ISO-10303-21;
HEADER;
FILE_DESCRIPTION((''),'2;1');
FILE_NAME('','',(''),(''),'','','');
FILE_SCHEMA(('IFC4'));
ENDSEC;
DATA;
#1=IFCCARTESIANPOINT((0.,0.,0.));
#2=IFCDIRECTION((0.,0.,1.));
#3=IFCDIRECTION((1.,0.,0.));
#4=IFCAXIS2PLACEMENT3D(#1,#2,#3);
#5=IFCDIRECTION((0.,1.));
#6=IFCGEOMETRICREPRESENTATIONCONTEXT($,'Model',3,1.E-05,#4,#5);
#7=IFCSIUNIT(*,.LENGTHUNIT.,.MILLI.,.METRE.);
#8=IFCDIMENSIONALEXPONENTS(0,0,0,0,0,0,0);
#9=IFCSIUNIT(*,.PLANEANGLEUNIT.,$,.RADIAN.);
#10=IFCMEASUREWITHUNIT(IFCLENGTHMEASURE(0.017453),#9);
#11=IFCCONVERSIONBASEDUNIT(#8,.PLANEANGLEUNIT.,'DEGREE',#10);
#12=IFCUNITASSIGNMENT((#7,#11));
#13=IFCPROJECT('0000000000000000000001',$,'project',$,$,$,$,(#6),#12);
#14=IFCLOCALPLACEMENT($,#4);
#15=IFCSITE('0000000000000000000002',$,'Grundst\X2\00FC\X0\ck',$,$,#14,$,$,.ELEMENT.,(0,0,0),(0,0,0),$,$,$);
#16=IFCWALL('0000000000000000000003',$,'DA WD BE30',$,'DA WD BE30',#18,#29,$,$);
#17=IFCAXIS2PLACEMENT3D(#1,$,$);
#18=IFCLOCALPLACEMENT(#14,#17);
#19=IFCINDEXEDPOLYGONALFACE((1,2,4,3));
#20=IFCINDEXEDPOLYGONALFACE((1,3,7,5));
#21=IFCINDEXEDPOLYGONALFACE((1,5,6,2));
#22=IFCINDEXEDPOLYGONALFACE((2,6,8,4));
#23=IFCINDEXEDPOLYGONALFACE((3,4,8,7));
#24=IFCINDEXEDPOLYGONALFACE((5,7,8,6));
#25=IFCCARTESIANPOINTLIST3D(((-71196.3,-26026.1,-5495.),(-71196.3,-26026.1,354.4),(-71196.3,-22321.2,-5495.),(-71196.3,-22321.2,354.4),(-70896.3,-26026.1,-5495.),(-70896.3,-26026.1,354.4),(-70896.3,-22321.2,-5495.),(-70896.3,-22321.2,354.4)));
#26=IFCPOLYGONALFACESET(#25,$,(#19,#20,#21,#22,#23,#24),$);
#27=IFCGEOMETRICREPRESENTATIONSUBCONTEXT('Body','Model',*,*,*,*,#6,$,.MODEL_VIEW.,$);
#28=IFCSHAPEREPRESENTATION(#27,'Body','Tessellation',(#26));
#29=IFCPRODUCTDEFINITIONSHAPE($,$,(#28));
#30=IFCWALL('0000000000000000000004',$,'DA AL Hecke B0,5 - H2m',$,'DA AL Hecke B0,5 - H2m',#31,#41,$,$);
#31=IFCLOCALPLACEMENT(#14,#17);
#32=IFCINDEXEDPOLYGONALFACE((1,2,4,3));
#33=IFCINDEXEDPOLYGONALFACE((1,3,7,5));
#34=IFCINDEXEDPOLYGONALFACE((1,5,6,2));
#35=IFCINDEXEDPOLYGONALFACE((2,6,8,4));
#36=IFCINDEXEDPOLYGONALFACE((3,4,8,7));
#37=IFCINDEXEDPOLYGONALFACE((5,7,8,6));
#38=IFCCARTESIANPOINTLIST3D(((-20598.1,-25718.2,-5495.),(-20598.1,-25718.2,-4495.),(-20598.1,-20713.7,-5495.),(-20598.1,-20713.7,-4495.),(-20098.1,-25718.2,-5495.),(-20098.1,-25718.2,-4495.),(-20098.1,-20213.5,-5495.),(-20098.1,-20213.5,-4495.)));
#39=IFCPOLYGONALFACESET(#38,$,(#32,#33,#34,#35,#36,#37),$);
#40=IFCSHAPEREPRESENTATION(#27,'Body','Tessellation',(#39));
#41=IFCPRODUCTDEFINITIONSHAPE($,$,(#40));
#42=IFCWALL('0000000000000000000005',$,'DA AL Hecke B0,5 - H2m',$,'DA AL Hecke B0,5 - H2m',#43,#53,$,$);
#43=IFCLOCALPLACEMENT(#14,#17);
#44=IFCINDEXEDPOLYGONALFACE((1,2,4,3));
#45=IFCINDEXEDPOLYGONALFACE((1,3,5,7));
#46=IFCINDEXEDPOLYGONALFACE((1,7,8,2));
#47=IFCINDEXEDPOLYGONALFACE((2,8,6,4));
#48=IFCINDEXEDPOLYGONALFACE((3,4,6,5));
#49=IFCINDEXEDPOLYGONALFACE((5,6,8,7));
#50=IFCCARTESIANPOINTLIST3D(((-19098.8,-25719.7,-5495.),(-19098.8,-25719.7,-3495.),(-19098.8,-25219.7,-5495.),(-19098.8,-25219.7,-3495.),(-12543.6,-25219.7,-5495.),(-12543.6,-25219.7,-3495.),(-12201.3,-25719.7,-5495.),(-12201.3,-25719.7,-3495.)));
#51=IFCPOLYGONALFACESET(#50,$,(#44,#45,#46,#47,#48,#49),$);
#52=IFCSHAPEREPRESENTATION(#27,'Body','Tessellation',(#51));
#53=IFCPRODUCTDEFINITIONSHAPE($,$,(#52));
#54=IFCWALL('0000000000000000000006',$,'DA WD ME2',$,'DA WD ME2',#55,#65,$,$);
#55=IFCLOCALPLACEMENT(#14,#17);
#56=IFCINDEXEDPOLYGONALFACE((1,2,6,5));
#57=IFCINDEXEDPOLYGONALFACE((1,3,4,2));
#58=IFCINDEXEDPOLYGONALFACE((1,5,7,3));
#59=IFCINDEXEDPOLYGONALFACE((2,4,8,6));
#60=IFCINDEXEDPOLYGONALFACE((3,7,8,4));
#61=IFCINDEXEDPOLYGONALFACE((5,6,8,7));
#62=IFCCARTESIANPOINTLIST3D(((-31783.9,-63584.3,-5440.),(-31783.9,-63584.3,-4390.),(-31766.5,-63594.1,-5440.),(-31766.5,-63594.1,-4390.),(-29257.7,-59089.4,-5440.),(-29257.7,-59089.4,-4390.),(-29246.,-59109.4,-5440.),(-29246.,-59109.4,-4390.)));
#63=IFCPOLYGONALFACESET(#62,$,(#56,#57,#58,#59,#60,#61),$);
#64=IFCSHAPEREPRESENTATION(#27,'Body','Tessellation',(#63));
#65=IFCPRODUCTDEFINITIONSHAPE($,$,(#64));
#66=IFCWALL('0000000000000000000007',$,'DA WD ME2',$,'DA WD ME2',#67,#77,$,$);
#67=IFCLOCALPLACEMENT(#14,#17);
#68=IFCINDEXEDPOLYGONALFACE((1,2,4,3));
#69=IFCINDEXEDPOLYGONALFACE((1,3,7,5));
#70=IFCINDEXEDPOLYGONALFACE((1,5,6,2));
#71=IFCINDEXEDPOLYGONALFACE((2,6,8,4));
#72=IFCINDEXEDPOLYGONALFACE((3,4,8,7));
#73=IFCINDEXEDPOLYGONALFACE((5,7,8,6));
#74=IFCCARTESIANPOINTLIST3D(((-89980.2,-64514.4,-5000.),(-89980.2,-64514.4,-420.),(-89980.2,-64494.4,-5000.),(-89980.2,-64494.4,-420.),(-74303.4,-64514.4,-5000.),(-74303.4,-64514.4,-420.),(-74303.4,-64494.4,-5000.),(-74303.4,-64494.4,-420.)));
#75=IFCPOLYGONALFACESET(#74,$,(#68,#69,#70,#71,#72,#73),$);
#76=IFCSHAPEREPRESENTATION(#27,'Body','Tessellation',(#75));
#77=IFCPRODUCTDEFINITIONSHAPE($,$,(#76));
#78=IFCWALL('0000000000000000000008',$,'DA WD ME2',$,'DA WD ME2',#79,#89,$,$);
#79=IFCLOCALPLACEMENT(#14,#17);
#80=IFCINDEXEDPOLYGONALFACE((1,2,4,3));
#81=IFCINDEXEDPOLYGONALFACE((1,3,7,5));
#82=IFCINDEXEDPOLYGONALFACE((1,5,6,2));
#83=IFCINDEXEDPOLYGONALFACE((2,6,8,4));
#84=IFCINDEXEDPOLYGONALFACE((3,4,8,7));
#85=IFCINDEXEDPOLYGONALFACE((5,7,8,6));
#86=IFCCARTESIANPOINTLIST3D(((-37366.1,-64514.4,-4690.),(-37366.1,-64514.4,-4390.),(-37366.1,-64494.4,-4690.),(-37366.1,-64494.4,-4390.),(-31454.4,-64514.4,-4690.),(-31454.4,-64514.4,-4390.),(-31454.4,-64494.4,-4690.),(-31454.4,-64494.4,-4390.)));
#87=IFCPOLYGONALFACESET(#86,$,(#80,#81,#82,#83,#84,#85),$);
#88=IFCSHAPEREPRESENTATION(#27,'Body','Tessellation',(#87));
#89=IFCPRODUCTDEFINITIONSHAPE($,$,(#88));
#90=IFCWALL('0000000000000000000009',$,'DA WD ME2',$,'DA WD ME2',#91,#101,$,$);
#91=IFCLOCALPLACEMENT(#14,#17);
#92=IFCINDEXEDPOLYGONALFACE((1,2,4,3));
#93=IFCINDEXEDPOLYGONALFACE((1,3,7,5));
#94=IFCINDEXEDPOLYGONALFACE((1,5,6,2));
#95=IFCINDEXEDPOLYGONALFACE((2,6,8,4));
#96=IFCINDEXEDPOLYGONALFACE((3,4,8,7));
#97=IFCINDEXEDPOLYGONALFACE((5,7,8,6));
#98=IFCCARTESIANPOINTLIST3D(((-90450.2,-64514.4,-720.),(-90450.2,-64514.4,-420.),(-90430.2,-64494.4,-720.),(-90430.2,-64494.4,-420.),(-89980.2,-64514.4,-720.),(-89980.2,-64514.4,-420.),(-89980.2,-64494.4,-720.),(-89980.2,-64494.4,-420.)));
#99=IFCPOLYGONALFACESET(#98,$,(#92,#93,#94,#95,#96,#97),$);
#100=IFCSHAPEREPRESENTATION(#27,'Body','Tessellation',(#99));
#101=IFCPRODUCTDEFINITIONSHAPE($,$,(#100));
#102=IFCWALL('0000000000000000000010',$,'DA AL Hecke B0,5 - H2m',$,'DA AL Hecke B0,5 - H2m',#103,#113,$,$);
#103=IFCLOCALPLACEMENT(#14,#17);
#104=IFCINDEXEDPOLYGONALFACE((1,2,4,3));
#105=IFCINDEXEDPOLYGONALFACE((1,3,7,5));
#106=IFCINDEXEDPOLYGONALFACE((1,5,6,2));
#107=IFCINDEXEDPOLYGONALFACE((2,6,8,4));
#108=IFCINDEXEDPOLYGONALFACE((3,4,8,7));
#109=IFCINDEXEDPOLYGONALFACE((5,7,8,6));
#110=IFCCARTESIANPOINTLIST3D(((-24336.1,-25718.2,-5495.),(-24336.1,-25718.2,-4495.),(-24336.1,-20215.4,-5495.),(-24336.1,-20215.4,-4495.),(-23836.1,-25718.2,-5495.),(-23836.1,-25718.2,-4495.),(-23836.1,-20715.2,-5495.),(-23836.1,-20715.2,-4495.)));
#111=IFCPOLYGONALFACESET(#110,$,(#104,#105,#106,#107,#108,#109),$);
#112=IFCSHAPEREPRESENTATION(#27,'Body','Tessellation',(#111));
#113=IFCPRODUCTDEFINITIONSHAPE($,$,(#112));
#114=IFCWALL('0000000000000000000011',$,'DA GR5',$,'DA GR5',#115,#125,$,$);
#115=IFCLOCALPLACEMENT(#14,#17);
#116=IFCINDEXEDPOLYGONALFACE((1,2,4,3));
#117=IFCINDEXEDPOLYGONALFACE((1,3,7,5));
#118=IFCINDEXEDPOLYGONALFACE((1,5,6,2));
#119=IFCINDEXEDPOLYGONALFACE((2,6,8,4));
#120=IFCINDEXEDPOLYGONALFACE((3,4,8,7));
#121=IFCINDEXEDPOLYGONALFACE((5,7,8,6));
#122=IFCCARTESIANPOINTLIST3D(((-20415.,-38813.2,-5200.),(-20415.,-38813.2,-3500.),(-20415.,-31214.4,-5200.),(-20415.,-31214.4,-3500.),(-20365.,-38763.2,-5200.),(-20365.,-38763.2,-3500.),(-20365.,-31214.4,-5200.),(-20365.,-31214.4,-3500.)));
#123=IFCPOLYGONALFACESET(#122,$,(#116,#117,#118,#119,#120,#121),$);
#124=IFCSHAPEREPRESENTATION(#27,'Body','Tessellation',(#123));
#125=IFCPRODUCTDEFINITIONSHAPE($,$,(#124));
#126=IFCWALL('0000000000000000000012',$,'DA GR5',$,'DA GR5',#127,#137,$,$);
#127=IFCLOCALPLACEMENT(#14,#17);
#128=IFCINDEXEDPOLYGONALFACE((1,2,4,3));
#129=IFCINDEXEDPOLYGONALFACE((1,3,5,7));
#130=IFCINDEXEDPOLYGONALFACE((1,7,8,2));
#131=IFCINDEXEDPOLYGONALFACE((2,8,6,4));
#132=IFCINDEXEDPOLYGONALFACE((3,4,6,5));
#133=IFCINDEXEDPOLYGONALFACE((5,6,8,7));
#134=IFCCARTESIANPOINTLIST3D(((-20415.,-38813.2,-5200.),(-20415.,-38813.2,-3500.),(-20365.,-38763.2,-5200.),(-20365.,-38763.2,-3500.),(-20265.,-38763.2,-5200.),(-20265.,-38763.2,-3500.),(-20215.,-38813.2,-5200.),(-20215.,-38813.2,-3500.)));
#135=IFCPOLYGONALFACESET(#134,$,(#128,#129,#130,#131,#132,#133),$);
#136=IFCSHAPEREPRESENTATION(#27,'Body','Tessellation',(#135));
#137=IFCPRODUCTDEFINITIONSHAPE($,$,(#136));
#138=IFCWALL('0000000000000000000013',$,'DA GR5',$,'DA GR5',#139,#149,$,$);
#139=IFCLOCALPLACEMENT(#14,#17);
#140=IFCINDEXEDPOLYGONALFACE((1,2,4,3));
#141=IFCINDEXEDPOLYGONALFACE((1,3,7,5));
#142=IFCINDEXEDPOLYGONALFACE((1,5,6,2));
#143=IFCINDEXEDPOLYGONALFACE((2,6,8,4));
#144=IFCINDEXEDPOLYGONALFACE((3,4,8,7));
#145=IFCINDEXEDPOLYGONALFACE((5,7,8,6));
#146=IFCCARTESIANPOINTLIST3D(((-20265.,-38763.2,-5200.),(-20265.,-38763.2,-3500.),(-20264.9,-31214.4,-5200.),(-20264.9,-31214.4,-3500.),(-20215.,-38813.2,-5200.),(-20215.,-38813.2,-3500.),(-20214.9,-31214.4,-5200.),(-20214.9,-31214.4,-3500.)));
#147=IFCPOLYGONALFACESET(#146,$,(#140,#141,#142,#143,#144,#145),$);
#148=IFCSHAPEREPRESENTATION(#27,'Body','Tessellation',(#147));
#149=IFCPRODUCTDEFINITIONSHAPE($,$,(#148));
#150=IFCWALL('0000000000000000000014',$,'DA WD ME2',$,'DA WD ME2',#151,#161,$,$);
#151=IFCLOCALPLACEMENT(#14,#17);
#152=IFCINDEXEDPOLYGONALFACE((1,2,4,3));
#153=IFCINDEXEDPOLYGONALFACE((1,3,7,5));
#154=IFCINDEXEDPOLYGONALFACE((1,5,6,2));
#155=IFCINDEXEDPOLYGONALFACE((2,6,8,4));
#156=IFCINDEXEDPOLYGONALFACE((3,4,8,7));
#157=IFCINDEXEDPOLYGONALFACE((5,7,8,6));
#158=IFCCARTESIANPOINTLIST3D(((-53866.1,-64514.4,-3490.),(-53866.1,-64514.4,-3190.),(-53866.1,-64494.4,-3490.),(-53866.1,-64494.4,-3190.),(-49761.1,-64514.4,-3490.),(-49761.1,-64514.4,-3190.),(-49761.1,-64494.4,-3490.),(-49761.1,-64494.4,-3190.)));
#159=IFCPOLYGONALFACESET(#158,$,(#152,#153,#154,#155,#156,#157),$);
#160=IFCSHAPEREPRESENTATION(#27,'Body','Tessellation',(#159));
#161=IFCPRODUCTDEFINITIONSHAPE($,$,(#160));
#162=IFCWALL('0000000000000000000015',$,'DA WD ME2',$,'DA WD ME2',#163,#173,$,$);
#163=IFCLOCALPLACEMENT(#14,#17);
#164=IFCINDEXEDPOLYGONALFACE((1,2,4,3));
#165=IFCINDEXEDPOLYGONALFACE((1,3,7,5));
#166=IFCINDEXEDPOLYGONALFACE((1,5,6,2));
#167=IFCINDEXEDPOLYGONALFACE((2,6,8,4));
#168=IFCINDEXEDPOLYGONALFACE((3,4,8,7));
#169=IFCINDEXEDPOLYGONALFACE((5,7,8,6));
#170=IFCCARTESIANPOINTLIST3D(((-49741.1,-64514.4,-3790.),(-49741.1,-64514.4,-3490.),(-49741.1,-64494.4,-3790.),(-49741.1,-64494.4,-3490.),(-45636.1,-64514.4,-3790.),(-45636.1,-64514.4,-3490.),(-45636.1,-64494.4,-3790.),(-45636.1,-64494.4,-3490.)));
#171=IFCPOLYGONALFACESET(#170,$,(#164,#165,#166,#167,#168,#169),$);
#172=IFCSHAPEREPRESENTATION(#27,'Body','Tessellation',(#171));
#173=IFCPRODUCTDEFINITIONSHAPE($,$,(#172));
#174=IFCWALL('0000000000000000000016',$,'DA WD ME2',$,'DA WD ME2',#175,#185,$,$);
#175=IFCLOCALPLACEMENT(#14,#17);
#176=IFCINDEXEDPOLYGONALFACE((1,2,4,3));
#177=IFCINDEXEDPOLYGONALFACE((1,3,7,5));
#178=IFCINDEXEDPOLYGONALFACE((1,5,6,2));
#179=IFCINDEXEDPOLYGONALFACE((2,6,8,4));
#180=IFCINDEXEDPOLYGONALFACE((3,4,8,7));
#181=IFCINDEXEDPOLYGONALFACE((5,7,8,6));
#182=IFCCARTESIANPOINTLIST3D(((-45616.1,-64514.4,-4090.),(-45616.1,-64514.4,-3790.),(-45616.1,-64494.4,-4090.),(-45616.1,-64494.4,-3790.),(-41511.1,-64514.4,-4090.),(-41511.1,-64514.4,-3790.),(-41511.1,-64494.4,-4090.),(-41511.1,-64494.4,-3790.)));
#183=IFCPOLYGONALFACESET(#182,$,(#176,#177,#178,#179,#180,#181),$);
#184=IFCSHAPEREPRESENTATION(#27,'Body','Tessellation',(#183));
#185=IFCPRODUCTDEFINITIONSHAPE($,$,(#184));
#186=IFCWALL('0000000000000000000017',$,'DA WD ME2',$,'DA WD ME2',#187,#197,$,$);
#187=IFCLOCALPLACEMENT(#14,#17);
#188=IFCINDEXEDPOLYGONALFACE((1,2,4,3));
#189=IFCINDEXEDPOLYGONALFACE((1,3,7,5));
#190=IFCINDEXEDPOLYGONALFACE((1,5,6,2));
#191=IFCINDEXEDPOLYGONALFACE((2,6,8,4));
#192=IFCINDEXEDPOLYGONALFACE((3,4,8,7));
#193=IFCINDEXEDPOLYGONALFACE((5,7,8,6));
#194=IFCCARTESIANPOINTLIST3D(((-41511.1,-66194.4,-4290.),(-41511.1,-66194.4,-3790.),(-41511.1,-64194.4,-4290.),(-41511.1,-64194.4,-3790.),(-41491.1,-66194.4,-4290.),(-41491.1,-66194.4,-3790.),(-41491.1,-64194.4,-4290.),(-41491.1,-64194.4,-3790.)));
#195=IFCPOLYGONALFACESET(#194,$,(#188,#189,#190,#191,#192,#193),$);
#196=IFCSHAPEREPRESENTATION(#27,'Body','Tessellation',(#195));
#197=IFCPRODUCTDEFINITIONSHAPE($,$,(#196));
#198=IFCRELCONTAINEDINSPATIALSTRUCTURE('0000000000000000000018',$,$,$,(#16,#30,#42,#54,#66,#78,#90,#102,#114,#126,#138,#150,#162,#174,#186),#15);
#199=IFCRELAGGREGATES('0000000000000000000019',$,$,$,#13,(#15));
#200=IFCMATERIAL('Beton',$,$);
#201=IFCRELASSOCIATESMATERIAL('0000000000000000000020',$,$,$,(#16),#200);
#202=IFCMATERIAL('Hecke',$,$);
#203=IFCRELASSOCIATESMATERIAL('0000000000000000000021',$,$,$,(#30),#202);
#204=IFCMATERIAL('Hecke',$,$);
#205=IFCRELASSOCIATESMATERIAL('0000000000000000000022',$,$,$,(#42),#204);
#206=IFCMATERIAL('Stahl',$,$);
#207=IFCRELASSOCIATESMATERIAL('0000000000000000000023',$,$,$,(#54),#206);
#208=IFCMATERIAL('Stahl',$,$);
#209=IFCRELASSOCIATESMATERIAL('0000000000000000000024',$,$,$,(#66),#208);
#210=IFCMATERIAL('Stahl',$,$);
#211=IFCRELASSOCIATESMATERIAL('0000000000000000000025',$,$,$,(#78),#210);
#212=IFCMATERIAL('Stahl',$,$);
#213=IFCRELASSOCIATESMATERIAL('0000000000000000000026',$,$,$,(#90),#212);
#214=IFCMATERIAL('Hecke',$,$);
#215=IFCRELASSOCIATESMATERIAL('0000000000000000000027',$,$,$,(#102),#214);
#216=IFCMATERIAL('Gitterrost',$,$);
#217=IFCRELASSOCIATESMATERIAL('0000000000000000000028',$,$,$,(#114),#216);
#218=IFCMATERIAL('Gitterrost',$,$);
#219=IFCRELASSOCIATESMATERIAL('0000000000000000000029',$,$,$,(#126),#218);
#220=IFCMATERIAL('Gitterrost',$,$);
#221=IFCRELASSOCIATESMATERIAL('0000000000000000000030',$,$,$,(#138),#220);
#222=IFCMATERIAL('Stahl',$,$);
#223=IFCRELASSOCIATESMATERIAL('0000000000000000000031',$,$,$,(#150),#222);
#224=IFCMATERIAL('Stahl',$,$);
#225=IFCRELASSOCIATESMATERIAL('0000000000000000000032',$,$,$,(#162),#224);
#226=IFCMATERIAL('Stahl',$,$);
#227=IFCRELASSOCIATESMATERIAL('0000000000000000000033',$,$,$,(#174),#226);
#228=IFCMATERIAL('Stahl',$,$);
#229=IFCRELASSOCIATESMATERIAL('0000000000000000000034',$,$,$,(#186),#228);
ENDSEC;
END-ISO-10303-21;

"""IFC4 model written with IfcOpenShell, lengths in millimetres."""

from ifc_helpers import new_model, entity, si_unit, converted_unit, direction, frame, origin_with_axes, place, context, subcontext, project, spatial, line, indexed_curve, outline, extrude, material, element, save


model = new_model("IFC4")

# Units and contexts
model_context = context("Model", 3, precision=1e-05, world=origin_with_axes(), true_north=direction((0.0, 1.0)))
body_context = subcontext(model_context, "Body", "Model", "MODEL_VIEW")
ifc_project = project(units=[si_unit("LENGTHUNIT", "METRE", prefix="MILLI"), converted_unit("PLANEANGLEUNIT", "DEGREE", entity("IfcLengthMeasure", 0.017453), si_unit("PLANEANGLEUNIT", "RADIAN"), dimensions=[0, 0, 0, 0, 0, 0, 0])], contexts=[model_context])

# Site
site_placement = place(None, origin_with_axes())
site = spatial("IfcSite", under=ifc_project, at=site_placement, Name="Grundstück", CompositionType="ELEMENT", RefLatitude=(0, 0, 0), RefLongitude=(0, 0, 0))

# Walls
ifc_material_1 = material(Name="Beton")
wall_1_placement = place(site_placement, frame((-71046.3, -26026.1, -5495.0), z_axis=(0.0, 0.0, 1.0), x_axis=(0.0, 1.0, 0.0)))
element("IfcWall", 1, at=wall_1_placement, inside=site, material=ifc_material_1, Name="DA WD BE30", ObjectType="DA WD BE30", context=body_context, shape_type="SweptSolid", body=[
    extrude(outline(indexed_curve([(0.0, -150.0), (0.0, 150.0), (3704.9, 150.0), (3704.9, -150.0)], segments=[line(1, 2), line(2, 3), line(3, 4), line(4, 1)])), origin_with_axes(), (0.0, 0.0, 1.0), 5849.4),
])
ifc_material_2 = material(Name="Hecke")
wall_2_placement = place(site_placement, frame((-20348.1, -20463.6, -5495.0), z_axis=(0.0, 0.0, 1.0), x_axis=(0.0, -1.0, 0.0)))
element("IfcWall", 2, at=wall_2_placement, inside=site, material=ifc_material_2, Name="DA AL Hecke B0,5 - H2m", ObjectType="DA AL Hecke B0,5 - H2m", context=body_context, shape_type="SweptSolid", body=[
    extrude(outline(indexed_curve([(250.1, -250.0), (-250.1, 250.0), (5254.6, 250.0), (5254.6, -250.0)], segments=[line(1, 2), line(2, 3), line(3, 4), line(4, 1)])), origin_with_axes(), (0.0, 0.0, 1.0), 1000.0),
])
ifc_material_3 = material(Name="Hecke")
wall_3_placement = place(site_placement, frame((-19098.8, -25469.7, -5495.0), z_axis=(0.0, 0.0, 1.0), x_axis=(1.0, 0.0, 0.0)))
element("IfcWall", 3, at=wall_3_placement, inside=site, material=ifc_material_3, Name="DA AL Hecke B0,5 - H2m", ObjectType="DA AL Hecke B0,5 - H2m", context=body_context, shape_type="SweptSolid", body=[
    extrude(outline(indexed_curve([(0.0, -250.0), (0.0, 250.0), (6555.2, 250.0), (6897.4, -250.0)], segments=[line(1, 2), line(2, 3), line(3, 4), line(4, 1)])), origin_with_axes(), (0.0, 0.0, 1.0), 2000.0),
])
ifc_material_4 = material(Name="Stahl")
wall_4_placement = place(site_placement, frame((-31775.2, -63589.2, -5440.0), z_axis=(0.0, 0.0, 1.0), x_axis=(0.489945, 0.871754, 0.0)))
element("IfcWall", 4, at=wall_4_placement, inside=site, material=ifc_material_4, Name="DA WD ME2", ObjectType="DA WD ME2", context=body_context, shape_type="SweptSolid", body=[
    extrude(outline(indexed_curve([(0.0, -10.0), (0.0, 10.0), (5156.2, 10.0), (5144.5, -10.0)], segments=[line(1, 2), line(2, 3), line(3, 4), line(4, 1)])), origin_with_axes(), (0.0, 0.0, 1.0), 1050.0),
])
ifc_material_5 = material(Name="Stahl")
wall_5_placement = place(site_placement, frame((-89980.2, -64504.4, -1320.0), z_axis=(0.0, 0.0, 1.0), x_axis=(1.0, 0.0, 0.0)))
element("IfcWall", 5, at=wall_5_placement, inside=site, material=ifc_material_5, Name="DA WD ME2", ObjectType="DA WD ME2", context=body_context, shape_type="SweptSolid", body=[
    extrude(outline(indexed_curve([(0.0, -10.0), (0.0, 10.0), (15676.8, 10.0), (15676.8, -10.0)], segments=[line(1, 2), line(2, 3), line(3, 4), line(4, 1)])), frame((0.0, 0.0, -3680.0), z_axis=(0.0, 0.0, 1.0), x_axis=(1.0, 0.0, 0.0)), (0.0, 0.0, 1.0), 4580.0),
])
ifc_material_6 = material(Name="Stahl")
wall_6_placement = place(site_placement, frame((-37366.1, -64504.4, -4690.0), z_axis=(0.0, 0.0, 1.0), x_axis=(1.0, 0.0, 0.0)))
element("IfcWall", 6, at=wall_6_placement, inside=site, material=ifc_material_6, Name="DA WD ME2", ObjectType="DA WD ME2", context=body_context, shape_type="SweptSolid", body=[
    extrude(outline(indexed_curve([(0.0, -10.0), (0.0, 10.0), (5911.6, 10.0), (5911.6, -10.0)], segments=[line(1, 2), line(2, 3), line(3, 4), line(4, 1)])), origin_with_axes(), (0.0, 0.0, 1.0), 300.0),
])
ifc_material_7 = material(Name="Stahl")
wall_7_placement = place(site_placement, frame((-90440.2, -64504.4, -720.0), z_axis=(0.0, 0.0, 1.0), x_axis=(1.0, 0.0, 0.0)))
element("IfcWall", 7, at=wall_7_placement, inside=site, material=ifc_material_7, Name="DA WD ME2", ObjectType="DA WD ME2", context=body_context, shape_type="SweptSolid", body=[
    extrude(outline(indexed_curve([(-10.0, -10.0), (10.0, 10.0), (460.1, 10.0), (460.1, -10.0)], segments=[line(1, 2), line(2, 3), line(3, 4), line(4, 1)])), origin_with_axes(), (0.0, 0.0, 1.0), 300.0),
])
ifc_material_8 = material(Name="Hecke")
wall_8_placement = place(site_placement, frame((-24086.1, -20465.3, -5495.0), z_axis=(0.0, 0.0, 1.0), x_axis=(0.0, -1.0, 0.0)))
element("IfcWall", 8, at=wall_8_placement, inside=site, material=ifc_material_8, Name="DA AL Hecke B0,5 - H2m", ObjectType="DA AL Hecke B0,5 - H2m", context=body_context, shape_type="SweptSolid", body=[
    extrude(outline(indexed_curve([(-249.9, -250.0), (249.9, 250.0), (5252.8, 250.0), (5252.8, -250.0)], segments=[line(1, 2), line(2, 3), line(3, 4), line(4, 1)])), origin_with_axes(), (0.0, 0.0, 1.0), 1000.0),
])
ifc_material_9 = material(Name="Gitterrost")
wall_9_placement = place(site_placement, frame((-20390.0, -38788.2, -5200.0), z_axis=(0.0, 0.0, 1.0), x_axis=(0.0, 1.0, 0.0)))
element("IfcWall", 9, at=wall_9_placement, inside=site, material=ifc_material_9, Name="DA GR5", ObjectType="DA GR5", context=body_context, shape_type="SweptSolid", body=[
    extrude(outline(indexed_curve([(25.0, -25.0), (-25.0, 25.0), (7573.8, 25.0), (7573.8, -25.0)], segments=[line(1, 2), line(2, 3), line(3, 4), line(4, 1)])), origin_with_axes(), (0.0, 0.0, 1.0), 1700.0),
])
ifc_material_10 = material(Name="Gitterrost")
wall_10_placement = place(site_placement, frame((-20240.0, -38788.2, -5200.0), z_axis=(0.0, 0.0, 1.0), x_axis=(-1.0, 0.000002, 0.0)))
element("IfcWall", 10, at=wall_10_placement, inside=site, material=ifc_material_10, Name="DA GR5", ObjectType="DA GR5", context=body_context, shape_type="SweptSolid", body=[
    extrude(outline(indexed_curve([(25.0, -25.0), (-25.0, 25.0), (175.0, 25.0), (125.0, -25.0)], segments=[line(1, 2), line(2, 3), line(3, 4), line(4, 1)])), origin_with_axes(), (0.0, 0.0, 1.0), 1700.0),
])
ifc_material_11 = material(Name="Gitterrost")
wall_11_placement = place(site_placement, frame((-20239.9, -31214.4, -5200.0), z_axis=(0.0, 0.0, 1.0), x_axis=(-0.000004, -1.0, 0.0)))
element("IfcWall", 11, at=wall_11_placement, inside=site, material=ifc_material_11, Name="DA GR5", ObjectType="DA GR5", context=body_context, shape_type="SweptSolid", body=[
    extrude(outline(indexed_curve([(0.0, -25.0), (0.0, 25.0), (7598.8, 25.0), (7548.8, -25.0)], segments=[line(1, 2), line(2, 3), line(3, 4), line(4, 1)])), origin_with_axes(), (0.0, 0.0, 1.0), 1700.0),
])
ifc_material_12 = material(Name="Stahl")
wall_12_placement = place(site_placement, frame((-53866.1, -64504.4, -3490.0), z_axis=(0.0, 0.0, 1.0), x_axis=(1.0, 0.0, 0.0)))
element("IfcWall", 12, at=wall_12_placement, inside=site, material=ifc_material_12, Name="DA WD ME2", ObjectType="DA WD ME2", context=body_context, shape_type="SweptSolid", body=[
    extrude(outline(indexed_curve([(0.0, -10.0), (0.0, 10.0), (4105.0, 10.0), (4105.0, -10.0)], segments=[line(1, 2), line(2, 3), line(3, 4), line(4, 1)])), origin_with_axes(), (0.0, 0.0, 1.0), 300.0),
])
ifc_material_13 = material(Name="Stahl")
wall_13_placement = place(site_placement, frame((-49741.1, -64504.4, -3790.0), z_axis=(0.0, 0.0, 1.0), x_axis=(1.0, 0.0, 0.0)))
element("IfcWall", 13, at=wall_13_placement, inside=site, material=ifc_material_13, Name="DA WD ME2", ObjectType="DA WD ME2", context=body_context, shape_type="SweptSolid", body=[
    extrude(outline(indexed_curve([(0.0, -10.0), (0.0, 10.0), (4105.0, 10.0), (4105.0, -10.0)], segments=[line(1, 2), line(2, 3), line(3, 4), line(4, 1)])), origin_with_axes(), (0.0, 0.0, 1.0), 300.0),
])
ifc_material_14 = material(Name="Stahl")
wall_14_placement = place(site_placement, frame((-45616.1, -64504.4, -4090.0), z_axis=(0.0, 0.0, 1.0), x_axis=(1.0, 0.0, 0.0)))
element("IfcWall", 14, at=wall_14_placement, inside=site, material=ifc_material_14, Name="DA WD ME2", ObjectType="DA WD ME2", context=body_context, shape_type="SweptSolid", body=[
    extrude(outline(indexed_curve([(0.0, -10.0), (0.0, 10.0), (4105.0, 10.0), (4105.0, -10.0)], segments=[line(1, 2), line(2, 3), line(3, 4), line(4, 1)])), origin_with_axes(), (0.0, 0.0, 1.0), 300.0),
])
ifc_material_15 = material(Name="Stahl")
wall_15_placement = place(site_placement, frame((-41501.1, -64194.4, -4290.0), z_axis=(0.0, 0.0, 1.0), x_axis=(0.0, -1.0, 0.0)))
element("IfcWall", 15, at=wall_15_placement, inside=site, material=ifc_material_15, Name="DA WD ME2", ObjectType="DA WD ME2", context=body_context, shape_type="SweptSolid", body=[
    extrude(outline(indexed_curve([(0.0, -10.0), (0.0, 10.0), (2000.0, 10.0), (2000.0, -10.0)], segments=[line(1, 2), line(2, 3), line(3, 4), line(4, 1)])), origin_with_axes(), (0.0, 0.0, 1.0), 500.0),
])

save(model, "model.ifc")
